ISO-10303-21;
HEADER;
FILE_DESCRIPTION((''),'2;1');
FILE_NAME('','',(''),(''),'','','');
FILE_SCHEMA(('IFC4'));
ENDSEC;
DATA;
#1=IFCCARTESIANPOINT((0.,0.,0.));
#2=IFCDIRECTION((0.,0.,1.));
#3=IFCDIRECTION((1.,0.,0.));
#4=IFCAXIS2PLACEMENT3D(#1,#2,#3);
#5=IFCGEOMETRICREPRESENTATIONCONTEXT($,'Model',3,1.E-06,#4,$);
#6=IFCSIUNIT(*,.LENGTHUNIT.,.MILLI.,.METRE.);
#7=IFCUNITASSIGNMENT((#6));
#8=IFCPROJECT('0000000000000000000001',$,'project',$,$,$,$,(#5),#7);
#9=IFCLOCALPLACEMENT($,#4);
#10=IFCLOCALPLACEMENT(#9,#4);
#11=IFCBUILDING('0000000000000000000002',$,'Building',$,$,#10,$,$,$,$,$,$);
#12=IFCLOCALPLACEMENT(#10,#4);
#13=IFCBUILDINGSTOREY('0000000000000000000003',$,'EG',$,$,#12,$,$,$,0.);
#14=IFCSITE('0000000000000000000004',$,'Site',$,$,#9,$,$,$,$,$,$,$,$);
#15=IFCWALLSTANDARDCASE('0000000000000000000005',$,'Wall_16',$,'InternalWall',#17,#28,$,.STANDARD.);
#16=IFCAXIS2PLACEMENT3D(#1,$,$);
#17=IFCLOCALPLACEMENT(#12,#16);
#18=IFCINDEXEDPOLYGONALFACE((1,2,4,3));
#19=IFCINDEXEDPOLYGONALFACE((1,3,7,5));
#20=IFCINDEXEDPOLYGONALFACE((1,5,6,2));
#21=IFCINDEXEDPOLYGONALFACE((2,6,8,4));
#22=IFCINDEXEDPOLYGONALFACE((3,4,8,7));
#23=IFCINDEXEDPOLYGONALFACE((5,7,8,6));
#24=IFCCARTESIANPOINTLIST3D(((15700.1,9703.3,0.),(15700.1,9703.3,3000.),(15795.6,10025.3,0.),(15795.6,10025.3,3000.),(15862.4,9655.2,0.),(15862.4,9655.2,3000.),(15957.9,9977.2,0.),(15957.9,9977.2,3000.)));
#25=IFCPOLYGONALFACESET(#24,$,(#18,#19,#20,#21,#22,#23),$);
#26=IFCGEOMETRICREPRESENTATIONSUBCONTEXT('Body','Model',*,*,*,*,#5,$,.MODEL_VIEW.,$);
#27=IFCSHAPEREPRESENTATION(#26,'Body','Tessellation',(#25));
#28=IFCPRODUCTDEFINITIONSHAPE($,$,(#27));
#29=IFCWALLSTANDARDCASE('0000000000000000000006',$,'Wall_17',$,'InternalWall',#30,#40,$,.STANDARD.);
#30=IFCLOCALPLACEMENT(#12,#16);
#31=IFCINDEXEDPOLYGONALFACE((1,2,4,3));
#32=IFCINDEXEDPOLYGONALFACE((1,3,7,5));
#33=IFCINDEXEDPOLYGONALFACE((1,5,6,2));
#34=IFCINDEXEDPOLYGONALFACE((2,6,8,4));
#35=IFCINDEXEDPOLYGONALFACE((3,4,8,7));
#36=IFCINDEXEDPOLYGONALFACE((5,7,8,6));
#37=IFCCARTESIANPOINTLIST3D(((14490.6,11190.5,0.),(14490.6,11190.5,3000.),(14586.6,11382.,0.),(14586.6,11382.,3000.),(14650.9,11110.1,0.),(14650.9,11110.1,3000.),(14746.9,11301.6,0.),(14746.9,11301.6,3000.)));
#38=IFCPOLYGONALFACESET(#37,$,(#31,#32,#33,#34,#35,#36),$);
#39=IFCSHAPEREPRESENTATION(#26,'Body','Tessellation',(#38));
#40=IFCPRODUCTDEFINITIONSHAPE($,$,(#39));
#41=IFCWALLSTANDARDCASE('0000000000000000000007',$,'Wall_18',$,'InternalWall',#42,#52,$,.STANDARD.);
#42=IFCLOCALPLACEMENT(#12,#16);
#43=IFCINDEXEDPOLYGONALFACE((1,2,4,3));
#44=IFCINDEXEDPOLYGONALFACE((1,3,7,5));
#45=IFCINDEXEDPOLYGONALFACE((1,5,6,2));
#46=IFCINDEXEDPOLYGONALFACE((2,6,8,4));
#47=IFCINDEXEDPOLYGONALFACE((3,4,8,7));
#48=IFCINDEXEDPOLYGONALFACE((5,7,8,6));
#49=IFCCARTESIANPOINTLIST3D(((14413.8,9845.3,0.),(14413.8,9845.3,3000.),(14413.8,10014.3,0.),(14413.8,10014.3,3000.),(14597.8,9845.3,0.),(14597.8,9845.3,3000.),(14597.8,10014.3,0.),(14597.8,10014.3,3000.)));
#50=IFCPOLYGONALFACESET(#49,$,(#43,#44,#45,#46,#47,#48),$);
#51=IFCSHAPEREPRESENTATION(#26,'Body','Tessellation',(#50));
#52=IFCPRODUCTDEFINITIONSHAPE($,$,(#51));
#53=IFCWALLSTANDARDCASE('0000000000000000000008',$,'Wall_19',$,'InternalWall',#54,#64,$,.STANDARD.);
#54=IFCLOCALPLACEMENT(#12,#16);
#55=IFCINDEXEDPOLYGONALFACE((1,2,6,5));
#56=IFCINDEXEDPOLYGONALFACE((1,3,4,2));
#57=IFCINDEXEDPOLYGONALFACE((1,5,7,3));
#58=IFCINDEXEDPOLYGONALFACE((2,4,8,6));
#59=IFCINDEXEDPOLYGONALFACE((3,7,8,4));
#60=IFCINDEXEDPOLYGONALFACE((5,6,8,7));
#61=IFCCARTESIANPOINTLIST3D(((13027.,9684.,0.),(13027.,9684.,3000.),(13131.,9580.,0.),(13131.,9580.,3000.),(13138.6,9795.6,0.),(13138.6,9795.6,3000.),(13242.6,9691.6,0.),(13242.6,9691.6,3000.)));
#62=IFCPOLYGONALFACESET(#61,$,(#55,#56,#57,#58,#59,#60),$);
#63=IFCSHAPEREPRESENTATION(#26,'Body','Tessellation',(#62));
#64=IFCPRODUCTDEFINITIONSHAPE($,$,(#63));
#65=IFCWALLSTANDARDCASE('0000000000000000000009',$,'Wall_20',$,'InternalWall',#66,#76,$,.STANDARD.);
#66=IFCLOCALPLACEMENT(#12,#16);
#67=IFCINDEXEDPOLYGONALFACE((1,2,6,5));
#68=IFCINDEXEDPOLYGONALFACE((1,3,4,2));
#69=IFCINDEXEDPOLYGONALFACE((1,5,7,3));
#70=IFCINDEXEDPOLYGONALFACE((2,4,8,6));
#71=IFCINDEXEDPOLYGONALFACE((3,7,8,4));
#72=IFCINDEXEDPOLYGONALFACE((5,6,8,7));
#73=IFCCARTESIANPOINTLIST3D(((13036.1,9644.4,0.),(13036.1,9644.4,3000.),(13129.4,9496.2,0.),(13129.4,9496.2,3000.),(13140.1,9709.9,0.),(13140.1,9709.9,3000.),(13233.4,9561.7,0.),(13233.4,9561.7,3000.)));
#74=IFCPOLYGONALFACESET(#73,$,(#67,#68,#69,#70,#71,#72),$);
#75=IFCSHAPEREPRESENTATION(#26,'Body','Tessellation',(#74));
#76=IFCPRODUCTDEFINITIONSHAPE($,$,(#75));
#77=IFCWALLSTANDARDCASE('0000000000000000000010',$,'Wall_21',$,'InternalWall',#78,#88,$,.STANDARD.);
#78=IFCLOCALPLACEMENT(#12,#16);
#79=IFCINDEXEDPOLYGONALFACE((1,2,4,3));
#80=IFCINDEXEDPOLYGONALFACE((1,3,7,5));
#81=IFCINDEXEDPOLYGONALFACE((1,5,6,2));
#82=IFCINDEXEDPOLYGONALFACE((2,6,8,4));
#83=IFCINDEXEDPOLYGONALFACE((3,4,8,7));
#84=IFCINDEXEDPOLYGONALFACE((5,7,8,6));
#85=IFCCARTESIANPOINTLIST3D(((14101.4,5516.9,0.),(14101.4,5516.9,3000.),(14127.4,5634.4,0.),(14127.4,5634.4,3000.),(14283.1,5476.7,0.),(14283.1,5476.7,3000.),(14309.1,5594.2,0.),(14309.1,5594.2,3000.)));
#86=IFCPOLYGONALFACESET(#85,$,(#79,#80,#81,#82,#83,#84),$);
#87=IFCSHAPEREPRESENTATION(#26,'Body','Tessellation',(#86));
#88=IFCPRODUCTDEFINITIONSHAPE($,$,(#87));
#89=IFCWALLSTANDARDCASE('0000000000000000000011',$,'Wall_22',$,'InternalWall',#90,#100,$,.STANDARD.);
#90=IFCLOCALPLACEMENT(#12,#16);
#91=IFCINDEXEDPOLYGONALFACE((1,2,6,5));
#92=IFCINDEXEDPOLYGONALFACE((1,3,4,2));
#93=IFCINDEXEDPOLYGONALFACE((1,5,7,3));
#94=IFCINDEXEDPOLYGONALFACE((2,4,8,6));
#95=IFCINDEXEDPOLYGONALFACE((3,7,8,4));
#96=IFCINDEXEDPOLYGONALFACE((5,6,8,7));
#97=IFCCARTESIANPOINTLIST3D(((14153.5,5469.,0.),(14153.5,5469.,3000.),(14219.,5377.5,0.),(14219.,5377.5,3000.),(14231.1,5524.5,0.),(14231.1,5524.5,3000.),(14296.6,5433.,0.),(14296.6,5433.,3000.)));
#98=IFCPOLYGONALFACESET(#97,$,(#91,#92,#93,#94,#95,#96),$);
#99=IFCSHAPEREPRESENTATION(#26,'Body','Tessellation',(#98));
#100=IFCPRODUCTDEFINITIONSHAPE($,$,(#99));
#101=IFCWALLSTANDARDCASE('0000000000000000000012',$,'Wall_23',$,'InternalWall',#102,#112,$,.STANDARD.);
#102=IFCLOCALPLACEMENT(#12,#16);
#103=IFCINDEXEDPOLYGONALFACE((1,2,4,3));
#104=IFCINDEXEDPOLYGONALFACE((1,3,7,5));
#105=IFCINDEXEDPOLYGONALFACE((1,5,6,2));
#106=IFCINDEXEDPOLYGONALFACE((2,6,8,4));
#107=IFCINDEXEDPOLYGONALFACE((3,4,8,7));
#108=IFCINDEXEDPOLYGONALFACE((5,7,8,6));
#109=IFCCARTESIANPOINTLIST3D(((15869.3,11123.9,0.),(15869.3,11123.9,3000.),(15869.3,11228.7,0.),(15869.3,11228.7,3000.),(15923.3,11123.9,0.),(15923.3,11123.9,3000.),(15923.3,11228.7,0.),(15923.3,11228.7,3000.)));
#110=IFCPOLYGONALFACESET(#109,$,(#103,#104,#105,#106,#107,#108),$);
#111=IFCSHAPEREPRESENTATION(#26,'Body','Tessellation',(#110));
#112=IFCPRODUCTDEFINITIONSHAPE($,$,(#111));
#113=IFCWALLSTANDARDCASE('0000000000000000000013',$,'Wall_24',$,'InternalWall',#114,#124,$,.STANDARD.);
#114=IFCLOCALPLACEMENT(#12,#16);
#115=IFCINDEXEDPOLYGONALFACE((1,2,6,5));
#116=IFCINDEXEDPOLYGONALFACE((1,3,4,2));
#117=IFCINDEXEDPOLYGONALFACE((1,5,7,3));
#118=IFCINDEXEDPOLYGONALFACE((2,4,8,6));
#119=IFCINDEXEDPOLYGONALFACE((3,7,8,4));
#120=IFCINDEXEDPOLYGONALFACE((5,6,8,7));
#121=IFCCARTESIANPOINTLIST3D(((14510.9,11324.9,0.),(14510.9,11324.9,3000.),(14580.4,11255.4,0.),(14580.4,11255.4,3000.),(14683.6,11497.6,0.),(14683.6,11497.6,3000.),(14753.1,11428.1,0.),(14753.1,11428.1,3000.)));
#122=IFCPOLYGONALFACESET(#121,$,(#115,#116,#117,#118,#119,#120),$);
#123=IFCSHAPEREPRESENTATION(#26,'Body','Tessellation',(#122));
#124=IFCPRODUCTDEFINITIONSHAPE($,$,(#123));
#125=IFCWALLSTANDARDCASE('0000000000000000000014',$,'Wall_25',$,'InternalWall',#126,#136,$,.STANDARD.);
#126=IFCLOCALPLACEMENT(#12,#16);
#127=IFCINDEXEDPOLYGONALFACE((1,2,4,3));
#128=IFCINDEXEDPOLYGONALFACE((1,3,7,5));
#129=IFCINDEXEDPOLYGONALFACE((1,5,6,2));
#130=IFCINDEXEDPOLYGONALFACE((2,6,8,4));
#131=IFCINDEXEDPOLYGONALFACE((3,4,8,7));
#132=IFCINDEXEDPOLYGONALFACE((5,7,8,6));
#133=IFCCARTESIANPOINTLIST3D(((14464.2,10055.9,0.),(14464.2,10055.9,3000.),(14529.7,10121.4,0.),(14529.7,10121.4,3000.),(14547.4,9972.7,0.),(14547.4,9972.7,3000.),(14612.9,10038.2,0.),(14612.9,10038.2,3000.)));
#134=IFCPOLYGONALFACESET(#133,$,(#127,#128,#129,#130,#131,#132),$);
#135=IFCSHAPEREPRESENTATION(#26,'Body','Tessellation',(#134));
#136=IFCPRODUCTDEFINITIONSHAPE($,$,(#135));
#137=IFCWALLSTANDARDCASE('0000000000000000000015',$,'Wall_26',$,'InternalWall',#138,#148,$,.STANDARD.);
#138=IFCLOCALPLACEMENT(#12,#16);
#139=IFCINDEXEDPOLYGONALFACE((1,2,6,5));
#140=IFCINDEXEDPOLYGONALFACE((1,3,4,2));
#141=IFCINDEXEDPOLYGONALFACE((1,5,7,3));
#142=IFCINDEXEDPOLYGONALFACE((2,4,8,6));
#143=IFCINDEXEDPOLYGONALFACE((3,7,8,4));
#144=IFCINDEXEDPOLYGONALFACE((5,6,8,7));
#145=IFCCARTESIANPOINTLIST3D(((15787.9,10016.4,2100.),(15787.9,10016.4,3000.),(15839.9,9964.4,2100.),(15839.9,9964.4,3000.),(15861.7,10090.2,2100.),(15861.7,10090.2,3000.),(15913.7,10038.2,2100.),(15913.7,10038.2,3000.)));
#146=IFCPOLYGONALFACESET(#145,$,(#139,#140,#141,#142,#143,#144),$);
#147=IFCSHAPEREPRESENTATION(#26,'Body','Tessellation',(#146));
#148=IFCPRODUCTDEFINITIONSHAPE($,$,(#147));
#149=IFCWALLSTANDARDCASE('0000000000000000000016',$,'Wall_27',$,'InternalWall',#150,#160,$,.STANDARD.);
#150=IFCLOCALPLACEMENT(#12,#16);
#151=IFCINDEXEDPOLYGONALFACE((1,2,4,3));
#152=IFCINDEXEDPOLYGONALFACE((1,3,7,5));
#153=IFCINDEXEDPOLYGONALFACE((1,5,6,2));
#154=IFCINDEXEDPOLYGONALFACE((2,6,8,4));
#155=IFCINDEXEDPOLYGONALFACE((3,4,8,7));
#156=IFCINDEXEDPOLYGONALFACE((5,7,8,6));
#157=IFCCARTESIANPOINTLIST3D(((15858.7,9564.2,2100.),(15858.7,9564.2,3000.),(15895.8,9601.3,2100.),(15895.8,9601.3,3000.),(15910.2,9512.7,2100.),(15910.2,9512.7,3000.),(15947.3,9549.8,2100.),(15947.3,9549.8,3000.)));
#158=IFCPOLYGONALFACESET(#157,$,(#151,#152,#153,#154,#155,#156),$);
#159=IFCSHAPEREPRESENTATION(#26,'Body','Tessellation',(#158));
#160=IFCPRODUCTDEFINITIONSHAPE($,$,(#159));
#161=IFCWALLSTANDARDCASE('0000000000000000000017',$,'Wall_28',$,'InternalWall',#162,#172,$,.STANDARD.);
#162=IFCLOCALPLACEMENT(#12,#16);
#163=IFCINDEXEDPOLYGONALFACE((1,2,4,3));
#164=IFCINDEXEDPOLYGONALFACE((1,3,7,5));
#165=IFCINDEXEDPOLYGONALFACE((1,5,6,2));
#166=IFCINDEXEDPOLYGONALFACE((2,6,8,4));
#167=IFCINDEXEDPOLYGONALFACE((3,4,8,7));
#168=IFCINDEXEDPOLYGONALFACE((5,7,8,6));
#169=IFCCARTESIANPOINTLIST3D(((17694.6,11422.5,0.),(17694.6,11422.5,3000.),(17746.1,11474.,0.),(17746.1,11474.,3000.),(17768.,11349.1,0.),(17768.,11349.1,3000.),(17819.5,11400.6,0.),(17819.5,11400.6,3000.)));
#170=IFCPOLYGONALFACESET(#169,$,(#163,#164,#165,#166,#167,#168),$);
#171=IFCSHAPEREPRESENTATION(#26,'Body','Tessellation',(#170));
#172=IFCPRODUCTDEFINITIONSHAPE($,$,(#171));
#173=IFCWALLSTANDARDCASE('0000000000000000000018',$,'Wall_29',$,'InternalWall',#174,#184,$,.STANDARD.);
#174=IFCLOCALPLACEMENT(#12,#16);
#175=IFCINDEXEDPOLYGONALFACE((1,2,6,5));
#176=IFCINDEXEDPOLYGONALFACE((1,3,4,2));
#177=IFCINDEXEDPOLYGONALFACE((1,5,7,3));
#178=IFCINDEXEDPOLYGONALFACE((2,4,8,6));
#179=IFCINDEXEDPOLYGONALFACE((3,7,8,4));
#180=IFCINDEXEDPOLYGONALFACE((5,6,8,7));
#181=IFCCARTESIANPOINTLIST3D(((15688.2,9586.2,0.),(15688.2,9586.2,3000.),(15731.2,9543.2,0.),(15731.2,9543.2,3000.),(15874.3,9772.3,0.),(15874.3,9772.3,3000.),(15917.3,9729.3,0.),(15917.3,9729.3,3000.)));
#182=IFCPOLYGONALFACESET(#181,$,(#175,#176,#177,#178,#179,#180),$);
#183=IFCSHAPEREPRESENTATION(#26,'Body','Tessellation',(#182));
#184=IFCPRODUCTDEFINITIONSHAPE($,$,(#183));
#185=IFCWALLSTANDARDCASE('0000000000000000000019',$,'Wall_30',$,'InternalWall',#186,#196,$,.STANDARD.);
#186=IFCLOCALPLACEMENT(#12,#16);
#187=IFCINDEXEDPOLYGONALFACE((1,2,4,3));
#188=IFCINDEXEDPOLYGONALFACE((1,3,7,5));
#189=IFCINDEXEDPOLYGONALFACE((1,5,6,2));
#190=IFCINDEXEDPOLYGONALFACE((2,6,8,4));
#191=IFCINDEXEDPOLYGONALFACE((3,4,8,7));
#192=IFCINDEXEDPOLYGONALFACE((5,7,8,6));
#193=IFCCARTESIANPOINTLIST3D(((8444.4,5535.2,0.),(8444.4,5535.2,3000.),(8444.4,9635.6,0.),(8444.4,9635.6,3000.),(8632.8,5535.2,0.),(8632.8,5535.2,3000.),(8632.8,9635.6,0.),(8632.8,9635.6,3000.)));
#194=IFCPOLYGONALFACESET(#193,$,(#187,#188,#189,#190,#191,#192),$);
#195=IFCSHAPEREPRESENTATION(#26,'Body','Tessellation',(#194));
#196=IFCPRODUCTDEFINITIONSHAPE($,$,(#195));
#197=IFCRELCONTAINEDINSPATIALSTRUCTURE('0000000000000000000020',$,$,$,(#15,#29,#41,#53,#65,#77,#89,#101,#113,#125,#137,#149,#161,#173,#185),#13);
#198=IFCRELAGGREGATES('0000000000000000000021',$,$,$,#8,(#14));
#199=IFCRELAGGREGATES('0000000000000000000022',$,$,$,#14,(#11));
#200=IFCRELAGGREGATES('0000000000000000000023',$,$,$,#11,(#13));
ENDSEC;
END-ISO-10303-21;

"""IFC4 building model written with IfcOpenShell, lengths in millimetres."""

from ifc_helpers import new_model, si_unit, frame, origin_with_axes, place, context, subcontext, project, spatial, rectangle, extrude, element, save


model = new_model("IFC4")

# Units and contexts
model_context = context("Model", 3, precision=1e-06, world=origin_with_axes())
body_context = subcontext(model_context, "Body", "Model", "MODEL_VIEW")
ifc_project = project(units=[si_unit("LENGTHUNIT", "METRE", prefix="MILLI")], contexts=[model_context])

# Site, building, storey
site_placement = place(None, origin_with_axes())
site = spatial("IfcSite", under=ifc_project, at=site_placement, Name="Site")
building_placement = place(site_placement, origin_with_axes())
building = spatial("IfcBuilding", under=site, at=building_placement, Name="Building")
storey_placement = place(building_placement, origin_with_axes())
storey = spatial("IfcBuildingStorey", under=building, at=storey_placement, Name="EG", Elevation=0.0)

# Walls
wall_1_placement = place(storey_placement, origin_with_axes())
element("IfcWallStandardCase", 1, at=wall_1_placement, inside=storey, Name="Wall_16", ObjectType="InternalWall", PredefinedType="STANDARD", context=body_context, shape_type="SweptSolid", body=[
    extrude(rectangle(XDim=335.9, YDim=169.3), frame((15829.0, 9840.3, 0.0), z_axis=(0.0, 0.0, 1.0), x_axis=(0.284342, 0.958723, 0.0)), (0.0, 0.0, 1.0), 3000.0),
])
wall_2_placement = place(storey_placement, origin_with_axes())
element("IfcWallStandardCase", 2, at=wall_2_placement, inside=storey, Name="Wall_17", ObjectType="InternalWall", PredefinedType="STANDARD", context=body_context, shape_type="SweptSolid", body=[
    extrude(rectangle(XDim=214.2, YDim=179.3), frame((14618.8, 11246.0, 0.0), z_axis=(0.0, 0.0, 1.0), x_axis=(-0.448147, -0.89396, 0.0)), (0.0, 0.0, 1.0), 3000.0),
])
wall_3_placement = place(storey_placement, origin_with_axes())
element("IfcWallStandardCase", 3, at=wall_3_placement, inside=storey, Name="Wall_18", ObjectType="InternalWall", PredefinedType="STANDARD", context=body_context, shape_type="SweptSolid", body=[
    extrude(rectangle(XDim=169.0, YDim=184.0), frame((14505.8, 9929.8, 0.0), z_axis=(0.0, 0.0, 1.0), x_axis=(0.0, -1.0, 0.0)), (0.0, 0.0, 1.0), 3000.0),
])
wall_4_placement = place(storey_placement, origin_with_axes())
element("IfcWallStandardCase", 4, at=wall_4_placement, inside=storey, Name="Wall_19", ObjectType="InternalWall", PredefinedType="STANDARD", context=body_context, shape_type="SweptSolid", body=[
    extrude(rectangle(XDim=147.1, YDim=157.9), frame((13134.8, 9687.8, 0.0), z_axis=(0.0, 0.0, 1.0), x_axis=(-0.707107, 0.707107, 0.0)), (0.0, 0.0, 1.0), 3000.0),
])
wall_5_placement = place(storey_placement, origin_with_axes())
element("IfcWallStandardCase", 5, at=wall_5_placement, inside=storey, Name="Wall_20", ObjectType="InternalWall", PredefinedType="STANDARD", context=body_context, shape_type="SweptSolid", body=[
    extrude(rectangle(XDim=122.9, YDim=175.1), frame((13134.8, 9603.0, 0.0), z_axis=(0.0, 0.0, 1.0), x_axis=(-0.846165, -0.532921, 0.0)), (0.0, 0.0, 1.0), 3000.0),
])
wall_6_placement = place(storey_placement, origin_with_axes())
element("IfcWallStandardCase", 6, at=wall_6_placement, inside=storey, Name="Wall_21", ObjectType="InternalWall", PredefinedType="STANDARD", context=body_context, shape_type="SweptSolid", body=[
    extrude(rectangle(XDim=120.3, YDim=186.1), frame((14205.3, 5555.5, 0.0), z_axis=(0.0, 0.0, 1.0), x_axis=(-0.216051, -0.976382, 0.0)), (0.0, 0.0, 1.0), 3000.0),
])
wall_7_placement = place(storey_placement, origin_with_axes())
element("IfcWallStandardCase", 7, at=wall_7_placement, inside=storey, Name="Wall_22", ObjectType="InternalWall", PredefinedType="STANDARD", context=body_context, shape_type="SweptSolid", body=[
    extrude(rectangle(XDim=112.5, YDim=95.4), frame((14225.0, 5451.0, 0.0), z_axis=(0.0, 0.0, 1.0), x_axis=(0.582079, -0.813133, 0.0)), (0.0, 0.0, 1.0), 3000.0),
])
wall_8_placement = place(storey_placement, origin_with_axes())
element("IfcWallStandardCase", 8, at=wall_8_placement, inside=storey, Name="Wall_23", ObjectType="InternalWall", PredefinedType="STANDARD", context=body_context, shape_type="SweptSolid", body=[
    extrude(rectangle(XDim=104.8, YDim=54.0), frame((15896.3, 11176.3, 0.0), z_axis=(0.0, 0.0, 1.0), x_axis=(0.0, 1.0, 0.0)), (0.0, 0.0, 1.0), 3000.0),
])
wall_9_placement = place(storey_placement, origin_with_axes())
element("IfcWallStandardCase", 9, at=wall_9_placement, inside=storey, Name="Wall_24", ObjectType="InternalWall", PredefinedType="STANDARD", context=body_context, shape_type="SweptSolid", body=[
    extrude(rectangle(XDim=98.3, YDim=244.2), frame((14632.0, 11376.5, 0.0), z_axis=(0.0, 0.0, 1.0), x_axis=(-0.707107, 0.707107, 0.0)), (0.0, 0.0, 1.0), 3000.0),
])
wall_10_placement = place(storey_placement, origin_with_axes())
element("IfcWallStandardCase", 10, at=wall_10_placement, inside=storey, Name="Wall_25", ObjectType="InternalWall", PredefinedType="STANDARD", context=body_context, shape_type="SweptSolid", body=[
    extrude(rectangle(XDim=92.6, YDim=117.6), frame((14538.5, 10047.0, 0.0), z_axis=(0.0, 0.0, 1.0), x_axis=(0.707107, 0.707107, 0.0)), (0.0, 0.0, 1.0), 3000.0),
])

# Walls, openings
wall_11_placement = place(storey_placement, origin_with_axes())
wall_11 = element("IfcWallStandardCase", 11, at=wall_11_placement, inside=storey, Name="Wall_26", ObjectType="InternalWall", PredefinedType="STANDARD", context=body_context, shape_type="SweptSolid", body=[
    extrude(rectangle(XDim=73.5, YDim=104.4), frame((15850.8, 10027.3, 0.0), z_axis=(0.0, 0.0, 1.0), x_axis=(-0.707107, 0.707107, 0.0)), (0.0, 0.0, 1.0), 3000.0),
])
opening_1_placement = place(wall_11_placement, origin_with_axes())
element("IfcOpeningElement", 12, at=opening_1_placement, inside=storey, cuts=wall_11, context=body_context, shape_type="SweptSolid", body=[
    extrude(rectangle(XDim=450.0, YDim=104.4), frame((15850.8, 10027.3, 0.0), z_axis=(0.0, 0.0, 1.0), x_axis=(-0.707107, 0.707107, 0.0)), (0.0, 0.0, 1.0), 2100.0),
])
wall_12_placement = place(storey_placement, origin_with_axes())
wall_12 = element("IfcWallStandardCase", 13, at=wall_12_placement, inside=storey, Name="Wall_27", ObjectType="InternalWall", PredefinedType="STANDARD", context=body_context, shape_type="SweptSolid", body=[
    extrude(rectangle(XDim=72.8, YDim=52.5), frame((15903.0, 9557.0, 0.0), z_axis=(0.0, 0.0, 1.0), x_axis=(0.707107, -0.707107, 0.0)), (0.0, 0.0, 1.0), 3000.0),
])
opening_2_placement = place(wall_12_placement, origin_with_axes())
element("IfcOpeningElement", 14, at=opening_2_placement, inside=storey, cuts=wall_12, context=body_context, shape_type="SweptSolid", body=[
    extrude(rectangle(XDim=450.0, YDim=52.5), frame((15903.0, 9557.0, 0.0), z_axis=(0.0, 0.0, 1.0), x_axis=(0.707107, -0.707107, 0.0)), (0.0, 0.0, 1.0), 2100.0),
])

# Walls
wall_13_placement = place(storey_placement, origin_with_axes())
element("IfcWallStandardCase", 15, at=wall_13_placement, inside=storey, Name="Wall_28", ObjectType="InternalWall", PredefinedType="STANDARD", context=body_context, shape_type="SweptSolid", body=[
    extrude(rectangle(XDim=72.8, YDim=103.8), frame((17757.0, 11411.5, 0.0), z_axis=(0.0, 0.0, 1.0), x_axis=(-0.707107, -0.707107, 0.0)), (0.0, 0.0, 1.0), 3000.0),
])
wall_14_placement = place(storey_placement, origin_with_axes())
element("IfcWallStandardCase", 16, at=wall_14_placement, inside=storey, Name="Wall_29", ObjectType="InternalWall", PredefinedType="STANDARD", context=body_context, shape_type="SweptSolid", body=[
    extrude(rectangle(XDim=60.8, YDim=263.1), frame((15802.8, 9657.8, 0.0), z_axis=(0.0, 0.0, 1.0), x_axis=(0.707107, -0.707107, 0.0)), (0.0, 0.0, 1.0), 3000.0),
])
wall_15_placement = place(storey_placement, origin_with_axes())
element("IfcWallStandardCase", 17, at=wall_15_placement, inside=storey, Name="Wall_30", ObjectType="InternalWall", PredefinedType="STANDARD", context=body_context, shape_type="SweptSolid", body=[
    extrude(rectangle(XDim=4100.3, YDim=188.4), frame((8538.6, 7585.4, 0.0), z_axis=(0.0, 0.0, 1.0), x_axis=(0.0, -1.0, 0.0)), (0.0, 0.0, 1.0), 3000.0),
])

save(model, "model.ifc")
